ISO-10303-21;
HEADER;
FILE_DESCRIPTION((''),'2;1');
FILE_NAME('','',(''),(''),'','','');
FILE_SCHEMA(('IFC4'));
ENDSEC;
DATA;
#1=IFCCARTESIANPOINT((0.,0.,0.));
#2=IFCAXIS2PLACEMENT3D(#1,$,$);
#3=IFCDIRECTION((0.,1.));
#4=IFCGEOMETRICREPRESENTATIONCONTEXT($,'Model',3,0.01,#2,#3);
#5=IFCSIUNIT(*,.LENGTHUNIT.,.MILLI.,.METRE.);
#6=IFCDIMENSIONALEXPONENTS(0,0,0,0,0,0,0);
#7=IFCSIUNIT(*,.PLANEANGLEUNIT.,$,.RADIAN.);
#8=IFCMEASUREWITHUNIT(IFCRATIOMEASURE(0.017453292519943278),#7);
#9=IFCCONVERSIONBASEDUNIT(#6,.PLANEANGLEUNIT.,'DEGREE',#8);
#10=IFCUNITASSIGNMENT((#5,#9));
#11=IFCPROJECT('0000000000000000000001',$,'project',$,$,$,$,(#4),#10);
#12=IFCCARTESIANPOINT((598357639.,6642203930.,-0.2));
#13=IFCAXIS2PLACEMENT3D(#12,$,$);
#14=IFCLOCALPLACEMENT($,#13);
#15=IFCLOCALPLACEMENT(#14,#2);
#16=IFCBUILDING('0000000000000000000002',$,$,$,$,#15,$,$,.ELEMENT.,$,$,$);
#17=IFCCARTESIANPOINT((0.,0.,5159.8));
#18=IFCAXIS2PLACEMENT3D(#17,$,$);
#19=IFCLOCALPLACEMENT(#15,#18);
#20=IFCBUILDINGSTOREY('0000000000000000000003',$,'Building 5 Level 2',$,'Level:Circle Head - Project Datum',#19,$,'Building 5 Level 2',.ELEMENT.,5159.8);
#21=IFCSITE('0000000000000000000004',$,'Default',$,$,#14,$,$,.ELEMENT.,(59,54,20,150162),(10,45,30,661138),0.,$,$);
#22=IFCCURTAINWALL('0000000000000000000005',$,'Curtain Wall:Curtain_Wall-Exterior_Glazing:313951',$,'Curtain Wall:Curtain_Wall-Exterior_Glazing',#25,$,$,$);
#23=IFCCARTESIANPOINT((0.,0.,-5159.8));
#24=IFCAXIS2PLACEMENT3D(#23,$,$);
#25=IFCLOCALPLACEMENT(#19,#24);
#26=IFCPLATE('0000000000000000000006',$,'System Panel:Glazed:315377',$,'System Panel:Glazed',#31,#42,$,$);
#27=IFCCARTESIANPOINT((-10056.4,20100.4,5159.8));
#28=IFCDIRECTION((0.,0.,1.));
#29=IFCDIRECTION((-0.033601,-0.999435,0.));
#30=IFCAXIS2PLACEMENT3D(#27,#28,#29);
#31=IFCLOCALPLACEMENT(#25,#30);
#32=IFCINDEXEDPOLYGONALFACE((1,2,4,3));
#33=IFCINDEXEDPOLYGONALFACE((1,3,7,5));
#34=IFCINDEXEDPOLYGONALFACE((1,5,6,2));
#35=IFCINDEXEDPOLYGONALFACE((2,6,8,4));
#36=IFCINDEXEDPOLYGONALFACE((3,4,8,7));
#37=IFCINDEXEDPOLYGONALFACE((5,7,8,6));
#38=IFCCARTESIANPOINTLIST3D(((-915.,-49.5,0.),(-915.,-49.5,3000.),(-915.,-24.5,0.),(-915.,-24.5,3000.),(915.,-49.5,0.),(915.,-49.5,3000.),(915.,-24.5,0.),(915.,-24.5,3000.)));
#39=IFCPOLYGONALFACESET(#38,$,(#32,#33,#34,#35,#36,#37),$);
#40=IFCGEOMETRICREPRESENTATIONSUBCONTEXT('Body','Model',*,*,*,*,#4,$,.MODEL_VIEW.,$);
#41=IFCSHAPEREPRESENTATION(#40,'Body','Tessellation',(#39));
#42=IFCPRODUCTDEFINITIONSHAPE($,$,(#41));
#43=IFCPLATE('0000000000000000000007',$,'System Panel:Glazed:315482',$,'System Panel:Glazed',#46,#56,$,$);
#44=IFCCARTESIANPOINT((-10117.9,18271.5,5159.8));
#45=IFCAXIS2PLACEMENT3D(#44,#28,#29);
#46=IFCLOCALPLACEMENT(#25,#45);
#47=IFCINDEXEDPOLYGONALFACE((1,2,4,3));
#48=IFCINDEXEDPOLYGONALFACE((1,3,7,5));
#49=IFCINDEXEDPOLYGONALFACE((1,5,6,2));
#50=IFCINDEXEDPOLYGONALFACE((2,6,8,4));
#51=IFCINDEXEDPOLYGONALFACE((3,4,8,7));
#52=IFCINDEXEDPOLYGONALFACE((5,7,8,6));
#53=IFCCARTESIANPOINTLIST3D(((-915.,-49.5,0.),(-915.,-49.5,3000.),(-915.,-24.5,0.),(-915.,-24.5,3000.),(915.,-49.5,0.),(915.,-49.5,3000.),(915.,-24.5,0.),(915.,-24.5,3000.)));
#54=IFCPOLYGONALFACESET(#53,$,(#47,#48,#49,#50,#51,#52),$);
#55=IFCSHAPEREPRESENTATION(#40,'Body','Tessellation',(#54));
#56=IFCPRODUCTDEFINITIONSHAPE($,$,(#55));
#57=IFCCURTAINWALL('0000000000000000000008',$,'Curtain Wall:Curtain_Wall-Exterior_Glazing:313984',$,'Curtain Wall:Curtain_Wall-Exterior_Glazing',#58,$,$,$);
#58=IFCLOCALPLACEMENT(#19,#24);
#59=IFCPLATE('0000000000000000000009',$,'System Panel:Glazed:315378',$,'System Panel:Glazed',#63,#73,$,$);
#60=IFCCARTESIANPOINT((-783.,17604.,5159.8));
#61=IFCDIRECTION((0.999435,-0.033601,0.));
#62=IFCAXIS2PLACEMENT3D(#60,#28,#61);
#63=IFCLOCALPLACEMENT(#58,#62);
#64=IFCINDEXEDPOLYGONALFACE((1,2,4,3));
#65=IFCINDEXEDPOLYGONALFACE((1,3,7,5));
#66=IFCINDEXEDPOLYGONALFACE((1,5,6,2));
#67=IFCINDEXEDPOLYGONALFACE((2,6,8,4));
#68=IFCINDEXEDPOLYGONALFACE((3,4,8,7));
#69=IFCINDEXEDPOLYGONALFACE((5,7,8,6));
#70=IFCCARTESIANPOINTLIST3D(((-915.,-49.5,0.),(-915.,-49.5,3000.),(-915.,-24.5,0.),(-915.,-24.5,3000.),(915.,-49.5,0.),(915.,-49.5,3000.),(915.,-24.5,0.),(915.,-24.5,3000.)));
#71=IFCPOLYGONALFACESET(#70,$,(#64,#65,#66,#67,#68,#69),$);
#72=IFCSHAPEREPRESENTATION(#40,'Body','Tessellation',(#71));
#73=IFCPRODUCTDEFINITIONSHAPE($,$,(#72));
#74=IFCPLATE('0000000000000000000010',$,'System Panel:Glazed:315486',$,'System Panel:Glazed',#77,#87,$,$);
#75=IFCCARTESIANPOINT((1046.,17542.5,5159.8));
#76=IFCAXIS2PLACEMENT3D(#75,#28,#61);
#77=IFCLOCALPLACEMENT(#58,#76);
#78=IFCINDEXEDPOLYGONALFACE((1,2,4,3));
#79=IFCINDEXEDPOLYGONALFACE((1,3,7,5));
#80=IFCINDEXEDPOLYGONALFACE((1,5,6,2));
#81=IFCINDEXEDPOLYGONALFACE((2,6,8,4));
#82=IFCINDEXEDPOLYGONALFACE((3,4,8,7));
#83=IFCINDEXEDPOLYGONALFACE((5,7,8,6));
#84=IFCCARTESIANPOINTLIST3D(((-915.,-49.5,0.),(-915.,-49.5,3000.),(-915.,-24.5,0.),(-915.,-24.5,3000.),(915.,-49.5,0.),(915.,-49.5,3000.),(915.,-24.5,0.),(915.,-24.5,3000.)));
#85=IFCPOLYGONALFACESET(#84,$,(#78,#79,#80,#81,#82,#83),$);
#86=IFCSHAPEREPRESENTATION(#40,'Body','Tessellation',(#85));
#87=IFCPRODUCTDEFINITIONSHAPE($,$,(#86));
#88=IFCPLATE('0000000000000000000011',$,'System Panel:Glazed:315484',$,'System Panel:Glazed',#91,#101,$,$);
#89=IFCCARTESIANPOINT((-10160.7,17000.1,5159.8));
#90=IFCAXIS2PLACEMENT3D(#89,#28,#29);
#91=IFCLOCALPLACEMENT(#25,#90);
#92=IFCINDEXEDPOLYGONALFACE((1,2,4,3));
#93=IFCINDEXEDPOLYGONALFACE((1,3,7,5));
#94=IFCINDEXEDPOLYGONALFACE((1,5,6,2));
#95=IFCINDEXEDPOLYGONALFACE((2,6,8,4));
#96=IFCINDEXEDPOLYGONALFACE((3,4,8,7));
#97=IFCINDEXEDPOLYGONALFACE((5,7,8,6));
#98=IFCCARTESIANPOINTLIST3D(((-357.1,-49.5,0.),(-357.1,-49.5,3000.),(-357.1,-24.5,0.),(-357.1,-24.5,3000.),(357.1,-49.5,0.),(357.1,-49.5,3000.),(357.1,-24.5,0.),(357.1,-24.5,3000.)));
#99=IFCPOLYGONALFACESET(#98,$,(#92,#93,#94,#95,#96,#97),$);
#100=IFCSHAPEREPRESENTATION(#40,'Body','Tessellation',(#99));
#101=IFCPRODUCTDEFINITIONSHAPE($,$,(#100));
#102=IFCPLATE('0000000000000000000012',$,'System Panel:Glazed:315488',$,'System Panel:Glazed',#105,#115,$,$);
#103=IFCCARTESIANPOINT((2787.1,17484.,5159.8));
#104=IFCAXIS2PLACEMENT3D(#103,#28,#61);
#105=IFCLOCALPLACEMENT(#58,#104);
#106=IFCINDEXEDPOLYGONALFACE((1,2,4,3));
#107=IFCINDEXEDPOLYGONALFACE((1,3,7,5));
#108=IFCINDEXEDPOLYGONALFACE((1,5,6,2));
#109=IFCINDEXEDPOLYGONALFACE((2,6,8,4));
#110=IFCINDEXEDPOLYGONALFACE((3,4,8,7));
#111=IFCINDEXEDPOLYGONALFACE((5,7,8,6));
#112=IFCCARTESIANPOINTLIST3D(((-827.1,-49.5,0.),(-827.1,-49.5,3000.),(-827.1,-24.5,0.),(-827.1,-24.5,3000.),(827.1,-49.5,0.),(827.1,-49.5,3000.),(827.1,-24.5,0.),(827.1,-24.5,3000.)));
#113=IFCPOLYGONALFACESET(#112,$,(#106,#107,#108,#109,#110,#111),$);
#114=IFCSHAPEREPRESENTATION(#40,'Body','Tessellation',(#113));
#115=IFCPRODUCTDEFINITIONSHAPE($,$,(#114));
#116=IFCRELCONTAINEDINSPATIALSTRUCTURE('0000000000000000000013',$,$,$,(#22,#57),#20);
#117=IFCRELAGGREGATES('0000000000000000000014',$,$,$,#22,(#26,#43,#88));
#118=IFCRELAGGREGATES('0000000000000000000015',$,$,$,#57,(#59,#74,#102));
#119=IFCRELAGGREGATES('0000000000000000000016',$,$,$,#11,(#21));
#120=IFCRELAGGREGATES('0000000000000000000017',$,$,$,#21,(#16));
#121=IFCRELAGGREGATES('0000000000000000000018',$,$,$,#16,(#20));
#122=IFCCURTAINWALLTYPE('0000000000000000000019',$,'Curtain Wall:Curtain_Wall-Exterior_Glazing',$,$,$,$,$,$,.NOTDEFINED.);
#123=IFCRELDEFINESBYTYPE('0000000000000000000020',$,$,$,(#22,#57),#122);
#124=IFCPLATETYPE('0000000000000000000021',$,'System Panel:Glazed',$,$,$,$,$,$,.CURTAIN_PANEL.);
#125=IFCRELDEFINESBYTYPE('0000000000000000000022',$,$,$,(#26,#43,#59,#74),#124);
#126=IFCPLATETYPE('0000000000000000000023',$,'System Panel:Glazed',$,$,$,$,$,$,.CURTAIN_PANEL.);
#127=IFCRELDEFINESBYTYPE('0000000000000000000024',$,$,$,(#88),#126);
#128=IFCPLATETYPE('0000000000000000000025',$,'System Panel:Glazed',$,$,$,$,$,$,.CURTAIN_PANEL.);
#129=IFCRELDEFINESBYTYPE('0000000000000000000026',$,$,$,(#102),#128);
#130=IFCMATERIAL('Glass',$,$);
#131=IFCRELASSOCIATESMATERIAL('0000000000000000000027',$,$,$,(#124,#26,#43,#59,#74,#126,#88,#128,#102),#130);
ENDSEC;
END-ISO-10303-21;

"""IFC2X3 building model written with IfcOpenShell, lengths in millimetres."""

from ifc_helpers import new_model, entity, si_unit, converted_unit, direction, frame, frame_2d, origin, place, context, subcontext, project, spatial, rectangle, extrude, source, transform, mapped, material, type_object, type_shapes, element, aggregate, save


model = new_model("IFC2X3")

# Units and contexts
model_context = context("Model", 3, precision=0.01, world=origin(), true_north=direction((0.0, 1.0)))
body_context = subcontext(model_context, "Body", "Model", "MODEL_VIEW")
ifc_project = project(units=[si_unit("LENGTHUNIT", "METRE", prefix="MILLI"), converted_unit("PLANEANGLEUNIT", "DEGREE", entity("IfcRatioMeasure", 0.017453292519943278), si_unit("PLANEANGLEUNIT", "RADIAN"), dimensions=[0, 0, 0, 0, 0, 0, 0])], contexts=[model_context])

# Site, building, storey
site_placement = place(None, frame((598357639.0, 6642203930.0, -0.2)))
site = spatial("IfcSite", under=ifc_project, at=site_placement, Name="Default", CompositionType="ELEMENT", RefLatitude=(59, 54, 20, 150162), RefLongitude=(10, 45, 30, 661138), RefElevation=0.0)
building_placement = place(site_placement, origin())
building = spatial("IfcBuilding", under=site, at=building_placement, CompositionType="ELEMENT")
storey_placement = place(building_placement, frame((0.0, 0.0, 5159.8)))
storey = spatial("IfcBuildingStorey", under=building, at=storey_placement, Name="Building 5 Level 2", ObjectType="Level:Circle Head - Project Datum", LongName="Building 5 Level 2", CompositionType="ELEMENT", Elevation=5159.8)

# Curtain walls, plates
curtain_wall_type = type_object("IfcCurtainWallType", Name="Curtain Wall:Curtain_Wall-Exterior_Glazing", PredefinedType="NOTDEFINED")
curtain_wall_1_placement = place(storey_placement, frame((0.0, 0.0, -5159.8)))
curtain_wall_1 = element("IfcCurtainWall", 1, at=curtain_wall_1_placement, inside=storey, type_object=curtain_wall_type, Name="Curtain Wall:Curtain_Wall-Exterior_Glazing:313951", ObjectType="Curtain Wall:Curtain_Wall-Exterior_Glazing")
ifc_material_1 = material(Name="Glass")
plate_type_1 = type_object("IfcPlateType", Name="System Panel:Glazed", PredefinedType="CURTAIN_PANEL", material=ifc_material_1)
shared_shape_1 = source(origin(), body_context, "Body", "SweptSolid", [
    extrude(rectangle(XDim=25.0, YDim=1830.0, at=frame_2d((0.0, 0.0), x_axis=(1.0, 0.0))), frame((0.0, -37.0, 0.0), z_axis=(0.0, 0.0, 1.0), x_axis=(0.0, 1.0, 0.0)), (0.0, 0.0, 1.0), 3000.0),
])
type_shapes(plate_type_1, [shared_shape_1])
plate_1_placement = place(curtain_wall_1_placement, frame((-10056.4, 20100.4, 5159.8), z_axis=(0.0, 0.0, 1.0), x_axis=(-0.033601, -0.999435, 0.0)))
plate_1 = element("IfcPlate", 2, at=plate_1_placement, type_object=plate_type_1, material=ifc_material_1, Name="System Panel:Glazed:315377", ObjectType="System Panel:Glazed", context=body_context, shape_type="MappedRepresentation", body=[
    mapped(shared_shape_1, transform((0.0, 0.0, 0.0), scale=1.0)),
])
plate_2_placement = place(curtain_wall_1_placement, frame((-10117.9, 18271.5, 5159.8), z_axis=(0.0, 0.0, 1.0), x_axis=(-0.033601, -0.999435, 0.0)))
plate_2 = element("IfcPlate", 3, at=plate_2_placement, type_object=plate_type_1, material=ifc_material_1, Name="System Panel:Glazed:315482", ObjectType="System Panel:Glazed", context=body_context, shape_type="MappedRepresentation", body=[
    mapped(shared_shape_1, transform((0.0, 0.0, 0.0), scale=1.0)),
])
curtain_wall_2_placement = place(storey_placement, frame((0.0, 0.0, -5159.8)))
curtain_wall_2 = element("IfcCurtainWall", 4, at=curtain_wall_2_placement, inside=storey, type_object=curtain_wall_type, Name="Curtain Wall:Curtain_Wall-Exterior_Glazing:313984", ObjectType="Curtain Wall:Curtain_Wall-Exterior_Glazing")
plate_3_placement = place(curtain_wall_2_placement, frame((-783.0, 17604.0, 5159.8), z_axis=(0.0, 0.0, 1.0), x_axis=(0.999435, -0.033601, 0.0)))
plate_3 = element("IfcPlate", 5, at=plate_3_placement, type_object=plate_type_1, material=ifc_material_1, Name="System Panel:Glazed:315378", ObjectType="System Panel:Glazed", context=body_context, shape_type="MappedRepresentation", body=[
    mapped(shared_shape_1, transform((0.0, 0.0, 0.0), scale=1.0)),
])
plate_4_placement = place(curtain_wall_2_placement, frame((1046.0, 17542.5, 5159.8), z_axis=(0.0, 0.0, 1.0), x_axis=(0.999435, -0.033601, 0.0)))
plate_4 = element("IfcPlate", 6, at=plate_4_placement, type_object=plate_type_1, material=ifc_material_1, Name="System Panel:Glazed:315486", ObjectType="System Panel:Glazed", context=body_context, shape_type="MappedRepresentation", body=[
    mapped(shared_shape_1, transform((0.0, 0.0, 0.0), scale=1.0)),
])

# Plates
plate_type_2 = type_object("IfcPlateType", Name="System Panel:Glazed", PredefinedType="CURTAIN_PANEL", material=ifc_material_1)
shared_shape_2 = source(origin(), body_context, "Body", "SweptSolid", [
    extrude(rectangle(XDim=25.0, YDim=714.2, at=frame_2d((0.0, 0.0), x_axis=(1.0, 0.0))), frame((0.0, -37.0, 0.0), z_axis=(0.0, 0.0, 1.0), x_axis=(0.0, 1.0, 0.0)), (0.0, 0.0, 1.0), 3000.0),
])
type_shapes(plate_type_2, [shared_shape_2])
plate_5_placement = place(curtain_wall_1_placement, frame((-10160.7, 17000.1, 5159.8), z_axis=(0.0, 0.0, 1.0), x_axis=(-0.033601, -0.999435, 0.0)))
plate_5 = element("IfcPlate", 7, at=plate_5_placement, type_object=plate_type_2, material=ifc_material_1, Name="System Panel:Glazed:315484", ObjectType="System Panel:Glazed", context=body_context, shape_type="MappedRepresentation", body=[
    mapped(shared_shape_2, transform((0.0, 0.0, 0.0), scale=1.0)),
])
aggregate(curtain_wall_1, [plate_1, plate_2, plate_5])
plate_type_3 = type_object("IfcPlateType", Name="System Panel:Glazed", PredefinedType="CURTAIN_PANEL", material=ifc_material_1)
shared_shape_3 = source(origin(), body_context, "Body", "SweptSolid", [
    extrude(rectangle(XDim=25.0, YDim=1654.3, at=frame_2d((0.0, 0.0), x_axis=(1.0, 0.0))), frame((0.0, -37.0, 0.0), z_axis=(0.0, 0.0, 1.0), x_axis=(0.0, 1.0, 0.0)), (0.0, 0.0, 1.0), 3000.0),
])
type_shapes(plate_type_3, [shared_shape_3])
plate_6_placement = place(curtain_wall_2_placement, frame((2787.1, 17484.0, 5159.8), z_axis=(0.0, 0.0, 1.0), x_axis=(0.999435, -0.033601, 0.0)))
plate_6 = element("IfcPlate", 8, at=plate_6_placement, type_object=plate_type_3, material=ifc_material_1, Name="System Panel:Glazed:315488", ObjectType="System Panel:Glazed", context=body_context, shape_type="MappedRepresentation", body=[
    mapped(shared_shape_3, transform((0.0, 0.0, 0.0), scale=1.0)),
])
aggregate(curtain_wall_2, [plate_3, plate_4, plate_6])

save(model, "model.ifc")
